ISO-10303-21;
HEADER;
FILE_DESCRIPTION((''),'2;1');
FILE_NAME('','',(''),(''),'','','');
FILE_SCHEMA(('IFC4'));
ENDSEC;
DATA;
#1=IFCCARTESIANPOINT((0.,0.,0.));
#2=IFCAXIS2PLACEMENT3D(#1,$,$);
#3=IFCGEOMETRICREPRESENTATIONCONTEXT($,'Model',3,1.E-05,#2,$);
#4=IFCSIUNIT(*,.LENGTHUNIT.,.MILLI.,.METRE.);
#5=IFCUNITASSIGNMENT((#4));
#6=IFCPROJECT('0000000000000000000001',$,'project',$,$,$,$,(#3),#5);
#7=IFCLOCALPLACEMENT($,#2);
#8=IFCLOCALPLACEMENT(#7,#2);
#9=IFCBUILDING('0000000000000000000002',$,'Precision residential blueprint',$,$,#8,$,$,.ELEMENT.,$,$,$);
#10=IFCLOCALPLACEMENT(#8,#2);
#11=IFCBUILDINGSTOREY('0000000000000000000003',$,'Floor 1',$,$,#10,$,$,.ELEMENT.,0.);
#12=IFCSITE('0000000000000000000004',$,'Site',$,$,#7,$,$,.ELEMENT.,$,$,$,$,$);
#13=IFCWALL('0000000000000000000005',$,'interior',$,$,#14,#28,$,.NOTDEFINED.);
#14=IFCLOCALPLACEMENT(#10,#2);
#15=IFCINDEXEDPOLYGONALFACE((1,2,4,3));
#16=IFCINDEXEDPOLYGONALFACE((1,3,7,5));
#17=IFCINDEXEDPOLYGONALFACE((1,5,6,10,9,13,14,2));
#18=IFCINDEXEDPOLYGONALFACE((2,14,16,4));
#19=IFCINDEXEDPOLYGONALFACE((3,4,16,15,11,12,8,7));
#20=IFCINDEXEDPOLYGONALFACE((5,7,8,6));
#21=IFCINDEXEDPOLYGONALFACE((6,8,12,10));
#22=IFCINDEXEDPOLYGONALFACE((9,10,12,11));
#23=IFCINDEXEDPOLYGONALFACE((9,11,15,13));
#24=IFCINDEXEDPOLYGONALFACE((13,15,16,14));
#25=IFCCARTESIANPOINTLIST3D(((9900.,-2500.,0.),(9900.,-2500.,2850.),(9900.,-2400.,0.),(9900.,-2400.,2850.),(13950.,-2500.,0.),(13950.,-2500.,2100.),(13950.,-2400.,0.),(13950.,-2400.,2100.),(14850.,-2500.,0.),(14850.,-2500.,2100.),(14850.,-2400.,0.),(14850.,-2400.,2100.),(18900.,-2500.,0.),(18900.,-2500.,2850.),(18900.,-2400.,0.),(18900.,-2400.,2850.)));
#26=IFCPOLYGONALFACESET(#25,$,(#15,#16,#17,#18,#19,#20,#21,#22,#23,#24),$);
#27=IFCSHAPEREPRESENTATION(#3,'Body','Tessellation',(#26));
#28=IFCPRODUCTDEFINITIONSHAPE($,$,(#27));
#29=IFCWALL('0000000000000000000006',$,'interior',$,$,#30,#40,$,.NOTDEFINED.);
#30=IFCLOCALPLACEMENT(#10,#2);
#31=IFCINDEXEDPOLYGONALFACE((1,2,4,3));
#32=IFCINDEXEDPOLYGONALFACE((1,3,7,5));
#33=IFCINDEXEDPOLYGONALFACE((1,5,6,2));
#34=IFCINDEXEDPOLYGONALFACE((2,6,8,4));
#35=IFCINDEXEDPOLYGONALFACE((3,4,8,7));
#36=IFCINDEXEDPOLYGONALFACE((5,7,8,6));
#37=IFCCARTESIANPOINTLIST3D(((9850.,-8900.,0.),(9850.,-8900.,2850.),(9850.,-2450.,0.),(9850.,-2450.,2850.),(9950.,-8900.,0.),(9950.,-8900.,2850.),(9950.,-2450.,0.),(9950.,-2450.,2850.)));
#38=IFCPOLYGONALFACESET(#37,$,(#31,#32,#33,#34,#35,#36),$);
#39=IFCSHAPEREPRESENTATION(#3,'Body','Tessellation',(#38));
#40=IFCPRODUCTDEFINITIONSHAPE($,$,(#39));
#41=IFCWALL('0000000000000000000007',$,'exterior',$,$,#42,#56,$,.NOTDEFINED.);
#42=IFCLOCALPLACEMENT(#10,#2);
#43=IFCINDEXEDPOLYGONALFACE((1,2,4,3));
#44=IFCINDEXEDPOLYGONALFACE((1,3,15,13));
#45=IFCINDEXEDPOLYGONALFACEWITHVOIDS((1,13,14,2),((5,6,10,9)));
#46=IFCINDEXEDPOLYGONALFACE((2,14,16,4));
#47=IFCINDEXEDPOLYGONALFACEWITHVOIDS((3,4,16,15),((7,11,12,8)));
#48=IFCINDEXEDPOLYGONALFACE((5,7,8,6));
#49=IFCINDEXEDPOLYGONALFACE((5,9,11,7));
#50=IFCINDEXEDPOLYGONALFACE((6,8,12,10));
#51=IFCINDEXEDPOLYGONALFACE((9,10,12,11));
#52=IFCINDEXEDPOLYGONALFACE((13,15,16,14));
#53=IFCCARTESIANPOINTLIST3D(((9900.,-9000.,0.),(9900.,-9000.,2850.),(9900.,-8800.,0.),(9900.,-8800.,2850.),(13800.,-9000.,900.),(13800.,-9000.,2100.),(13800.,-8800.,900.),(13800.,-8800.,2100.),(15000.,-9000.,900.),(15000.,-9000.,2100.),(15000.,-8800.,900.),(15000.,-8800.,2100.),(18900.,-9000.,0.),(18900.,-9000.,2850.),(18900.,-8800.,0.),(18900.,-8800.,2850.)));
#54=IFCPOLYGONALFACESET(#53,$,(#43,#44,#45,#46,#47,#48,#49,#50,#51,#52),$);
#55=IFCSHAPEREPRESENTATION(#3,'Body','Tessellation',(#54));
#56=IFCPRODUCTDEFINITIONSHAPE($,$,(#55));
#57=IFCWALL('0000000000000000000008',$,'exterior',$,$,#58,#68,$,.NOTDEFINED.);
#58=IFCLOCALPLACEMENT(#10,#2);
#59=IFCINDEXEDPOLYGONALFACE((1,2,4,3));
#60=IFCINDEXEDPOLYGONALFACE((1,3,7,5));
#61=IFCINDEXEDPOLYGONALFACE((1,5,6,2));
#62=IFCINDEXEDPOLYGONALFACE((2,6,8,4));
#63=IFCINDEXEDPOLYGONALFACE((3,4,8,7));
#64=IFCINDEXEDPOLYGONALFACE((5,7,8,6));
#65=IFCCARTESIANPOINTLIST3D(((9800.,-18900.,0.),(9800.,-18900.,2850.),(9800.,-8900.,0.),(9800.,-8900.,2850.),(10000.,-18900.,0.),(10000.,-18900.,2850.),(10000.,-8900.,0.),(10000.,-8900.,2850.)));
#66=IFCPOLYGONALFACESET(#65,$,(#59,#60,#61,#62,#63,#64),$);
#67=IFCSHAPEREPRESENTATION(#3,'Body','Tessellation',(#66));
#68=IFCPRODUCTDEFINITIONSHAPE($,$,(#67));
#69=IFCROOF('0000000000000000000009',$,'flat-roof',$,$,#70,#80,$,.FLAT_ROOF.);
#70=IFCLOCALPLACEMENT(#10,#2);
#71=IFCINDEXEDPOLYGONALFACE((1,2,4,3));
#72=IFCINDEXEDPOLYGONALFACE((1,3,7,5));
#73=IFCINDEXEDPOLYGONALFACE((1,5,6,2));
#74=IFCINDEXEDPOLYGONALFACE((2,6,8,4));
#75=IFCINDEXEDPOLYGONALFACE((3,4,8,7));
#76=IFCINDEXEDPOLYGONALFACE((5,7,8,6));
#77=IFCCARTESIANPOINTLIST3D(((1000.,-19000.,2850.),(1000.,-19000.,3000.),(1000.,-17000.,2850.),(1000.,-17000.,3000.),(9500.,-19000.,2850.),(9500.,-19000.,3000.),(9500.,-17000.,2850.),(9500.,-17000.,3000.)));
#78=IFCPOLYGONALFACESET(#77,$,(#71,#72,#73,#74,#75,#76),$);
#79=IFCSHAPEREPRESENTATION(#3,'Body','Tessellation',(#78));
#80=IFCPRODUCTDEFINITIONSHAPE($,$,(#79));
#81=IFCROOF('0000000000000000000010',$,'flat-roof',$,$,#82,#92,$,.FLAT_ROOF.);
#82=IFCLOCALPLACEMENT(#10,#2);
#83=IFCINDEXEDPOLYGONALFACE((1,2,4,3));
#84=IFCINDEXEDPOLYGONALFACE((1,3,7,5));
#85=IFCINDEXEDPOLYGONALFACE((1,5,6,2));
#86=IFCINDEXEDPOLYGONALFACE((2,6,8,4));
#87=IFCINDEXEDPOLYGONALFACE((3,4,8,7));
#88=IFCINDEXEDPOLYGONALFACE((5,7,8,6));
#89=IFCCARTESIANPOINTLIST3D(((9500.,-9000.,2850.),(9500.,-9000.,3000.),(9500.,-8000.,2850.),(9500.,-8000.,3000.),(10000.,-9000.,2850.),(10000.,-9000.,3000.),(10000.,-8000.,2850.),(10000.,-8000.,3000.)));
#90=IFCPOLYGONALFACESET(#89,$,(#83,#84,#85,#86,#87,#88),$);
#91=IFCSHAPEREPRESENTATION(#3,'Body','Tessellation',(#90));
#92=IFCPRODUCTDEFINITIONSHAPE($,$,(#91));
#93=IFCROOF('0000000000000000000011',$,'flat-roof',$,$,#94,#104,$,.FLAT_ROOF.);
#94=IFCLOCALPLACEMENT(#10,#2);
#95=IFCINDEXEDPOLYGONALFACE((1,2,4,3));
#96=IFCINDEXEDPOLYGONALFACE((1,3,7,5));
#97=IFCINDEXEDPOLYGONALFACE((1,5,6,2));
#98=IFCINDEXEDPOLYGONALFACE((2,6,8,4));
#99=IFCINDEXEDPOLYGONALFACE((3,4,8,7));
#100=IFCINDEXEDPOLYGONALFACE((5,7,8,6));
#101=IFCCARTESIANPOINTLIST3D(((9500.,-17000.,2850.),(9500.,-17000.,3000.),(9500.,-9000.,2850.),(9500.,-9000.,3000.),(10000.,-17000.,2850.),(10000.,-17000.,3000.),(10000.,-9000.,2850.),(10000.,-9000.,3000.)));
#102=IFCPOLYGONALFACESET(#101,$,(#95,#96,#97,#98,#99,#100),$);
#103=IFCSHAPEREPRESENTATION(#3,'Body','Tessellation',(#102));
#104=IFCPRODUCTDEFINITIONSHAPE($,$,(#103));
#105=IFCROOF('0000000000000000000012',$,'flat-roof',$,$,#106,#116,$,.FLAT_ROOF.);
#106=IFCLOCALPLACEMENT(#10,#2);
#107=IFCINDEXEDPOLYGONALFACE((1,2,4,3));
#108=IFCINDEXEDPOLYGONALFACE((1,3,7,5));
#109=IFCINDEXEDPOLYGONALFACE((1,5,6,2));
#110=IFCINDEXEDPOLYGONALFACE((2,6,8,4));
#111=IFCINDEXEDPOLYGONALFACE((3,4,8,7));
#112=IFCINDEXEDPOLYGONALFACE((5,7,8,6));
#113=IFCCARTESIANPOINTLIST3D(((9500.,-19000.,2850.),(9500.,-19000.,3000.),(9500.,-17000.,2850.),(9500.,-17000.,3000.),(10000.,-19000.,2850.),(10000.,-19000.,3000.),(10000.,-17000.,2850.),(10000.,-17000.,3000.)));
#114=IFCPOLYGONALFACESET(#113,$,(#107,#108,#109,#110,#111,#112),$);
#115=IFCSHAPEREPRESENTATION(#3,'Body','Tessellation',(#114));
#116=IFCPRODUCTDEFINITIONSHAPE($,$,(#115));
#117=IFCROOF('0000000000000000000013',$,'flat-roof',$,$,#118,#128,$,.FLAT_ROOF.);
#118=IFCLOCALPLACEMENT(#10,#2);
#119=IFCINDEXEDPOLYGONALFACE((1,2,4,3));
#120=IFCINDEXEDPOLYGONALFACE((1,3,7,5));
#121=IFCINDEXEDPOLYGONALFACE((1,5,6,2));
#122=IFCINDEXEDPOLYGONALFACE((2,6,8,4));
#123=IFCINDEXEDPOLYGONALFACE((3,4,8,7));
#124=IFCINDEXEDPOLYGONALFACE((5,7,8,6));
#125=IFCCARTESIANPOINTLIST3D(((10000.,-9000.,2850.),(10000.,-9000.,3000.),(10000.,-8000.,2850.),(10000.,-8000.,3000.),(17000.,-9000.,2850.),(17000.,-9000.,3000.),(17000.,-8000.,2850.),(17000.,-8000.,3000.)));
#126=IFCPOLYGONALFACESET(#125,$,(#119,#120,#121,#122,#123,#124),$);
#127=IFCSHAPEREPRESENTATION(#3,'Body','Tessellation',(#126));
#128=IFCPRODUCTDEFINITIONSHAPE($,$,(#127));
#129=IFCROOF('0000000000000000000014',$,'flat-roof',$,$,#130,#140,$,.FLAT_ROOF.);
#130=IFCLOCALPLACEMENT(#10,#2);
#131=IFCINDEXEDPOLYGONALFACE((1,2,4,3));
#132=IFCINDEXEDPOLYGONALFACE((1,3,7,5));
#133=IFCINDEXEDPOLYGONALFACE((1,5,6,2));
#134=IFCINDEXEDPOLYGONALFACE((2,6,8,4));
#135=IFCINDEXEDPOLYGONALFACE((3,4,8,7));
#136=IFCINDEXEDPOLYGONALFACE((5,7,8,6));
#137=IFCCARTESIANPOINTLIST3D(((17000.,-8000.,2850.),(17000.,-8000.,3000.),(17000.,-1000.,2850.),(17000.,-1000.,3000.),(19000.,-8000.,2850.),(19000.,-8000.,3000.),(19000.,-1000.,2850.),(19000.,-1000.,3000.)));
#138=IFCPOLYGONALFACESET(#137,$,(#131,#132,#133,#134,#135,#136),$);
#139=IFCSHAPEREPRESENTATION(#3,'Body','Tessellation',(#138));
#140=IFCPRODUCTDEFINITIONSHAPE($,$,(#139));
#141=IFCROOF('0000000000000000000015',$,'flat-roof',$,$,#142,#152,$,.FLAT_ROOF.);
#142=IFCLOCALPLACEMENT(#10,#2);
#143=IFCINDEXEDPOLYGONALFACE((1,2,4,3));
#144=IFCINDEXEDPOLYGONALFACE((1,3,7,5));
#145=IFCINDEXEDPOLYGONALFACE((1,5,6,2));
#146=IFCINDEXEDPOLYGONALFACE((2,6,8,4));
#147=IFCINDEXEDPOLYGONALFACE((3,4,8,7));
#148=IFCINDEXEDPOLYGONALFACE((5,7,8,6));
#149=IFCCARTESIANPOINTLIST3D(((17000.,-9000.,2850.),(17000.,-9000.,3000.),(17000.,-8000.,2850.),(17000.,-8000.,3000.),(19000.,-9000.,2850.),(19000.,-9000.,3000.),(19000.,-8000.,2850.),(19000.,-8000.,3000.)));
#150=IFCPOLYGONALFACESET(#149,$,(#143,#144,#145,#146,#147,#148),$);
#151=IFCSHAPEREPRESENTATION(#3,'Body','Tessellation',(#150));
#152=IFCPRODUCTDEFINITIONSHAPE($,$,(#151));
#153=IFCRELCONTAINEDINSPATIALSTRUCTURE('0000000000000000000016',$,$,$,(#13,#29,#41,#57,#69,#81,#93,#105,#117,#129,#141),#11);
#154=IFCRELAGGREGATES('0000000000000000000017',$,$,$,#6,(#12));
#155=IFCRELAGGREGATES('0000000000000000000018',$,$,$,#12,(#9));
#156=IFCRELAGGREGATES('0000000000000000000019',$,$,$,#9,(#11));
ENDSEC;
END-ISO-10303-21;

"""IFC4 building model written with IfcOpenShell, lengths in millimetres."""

from ifc_helpers import new_model, si_unit, frame, origin, place, context, project, spatial, polyline, outline, extrude, element, save


model = new_model("IFC4")

# Units and contexts
model_context = context("Model", 3, precision=1e-05, world=origin())
ifc_project = project(units=[si_unit("LENGTHUNIT", "METRE", prefix="MILLI")], contexts=[model_context])

# Site, building, storey
site_placement = place(None, origin())
site = spatial("IfcSite", under=ifc_project, at=site_placement, Name="Site", CompositionType="ELEMENT")
building_placement = place(site_placement, origin())
building = spatial("IfcBuilding", under=site, at=building_placement, Name="Precision residential blueprint", CompositionType="ELEMENT")
storey_placement = place(building_placement, origin())
storey = spatial("IfcBuildingStorey", under=building, at=storey_placement, Name="Floor 1", CompositionType="ELEMENT", Elevation=0.0)

# Wall, opening
wall_1_placement = place(storey_placement, origin())
wall_1 = element("IfcWall", 1, at=wall_1_placement, inside=storey, Name="interior", PredefinedType="NOTDEFINED", context=model_context, shape_type="SweptSolid", body=[
    extrude(outline(polyline([(9900.0, -2400.0), (18900.0, -2400.0), (18900.0, -2500.0), (9900.0, -2500.0), (9900.0, -2400.0)])), origin(), (0.0, 0.0, 1.0), 2850.0),
])
opening_1_placement = place(storey_placement, origin())
element("IfcOpeningElement", 2, at=opening_1_placement, cuts=wall_1, PredefinedType="OPENING", context=model_context, shape_type="SweptSolid", body=[
    extrude(outline(polyline([(13950.0, -2400.0), (14850.0, -2400.0), (14850.0, -2500.0), (13950.0, -2500.0), (13950.0, -2400.0)])), origin(), (0.0, 0.0, 1.0), 2100.0),
])

# Wall
wall_2_placement = place(storey_placement, origin())
element("IfcWall", 3, at=wall_2_placement, inside=storey, Name="interior", PredefinedType="NOTDEFINED", context=model_context, shape_type="SweptSolid", body=[
    extrude(outline(polyline([(9950.0, -2450.0), (9950.0, -8900.0), (9850.0, -8900.0), (9850.0, -2450.0), (9950.0, -2450.0)])), origin(), (0.0, 0.0, 1.0), 2850.0),
])

# Wall, opening
wall_3_placement = place(storey_placement, origin())
wall_3 = element("IfcWall", 4, at=wall_3_placement, inside=storey, Name="exterior", PredefinedType="NOTDEFINED", context=model_context, shape_type="SweptSolid", body=[
    extrude(outline(polyline([(9900.0, -8800.0), (18900.0, -8800.0), (18900.0, -9000.0), (9900.0, -9000.0), (9900.0, -8800.0)])), origin(), (0.0, 0.0, 1.0), 2850.0),
])
opening_2_placement = place(storey_placement, origin())
element("IfcOpeningElement", 5, at=opening_2_placement, cuts=wall_3, PredefinedType="OPENING", context=model_context, shape_type="SweptSolid", body=[
    extrude(outline(polyline([(13800.0, -8800.0), (15000.0, -8800.0), (15000.0, -9000.0), (13800.0, -9000.0), (13800.0, -8800.0)])), frame((0.0, 0.0, 900.0)), (0.0, 0.0, 1.0), 1200.0),
])

# Wall
wall_4_placement = place(storey_placement, origin())
element("IfcWall", 6, at=wall_4_placement, inside=storey, Name="exterior", PredefinedType="NOTDEFINED", context=model_context, shape_type="SweptSolid", body=[
    extrude(outline(polyline([(10000.0, -8900.0), (10000.0, -18900.0), (9800.0, -18900.0), (9800.0, -8900.0), (10000.0, -8900.0)])), origin(), (0.0, 0.0, 1.0), 2850.0),
])

# Roofs
roof_1_placement = place(storey_placement, origin())
element("IfcRoof", 7, at=roof_1_placement, inside=storey, Name="flat-roof", PredefinedType="FLAT_ROOF", context=model_context, shape_type="SweptSolid", body=[
    extrude(outline(polyline([(1000.0, -19000.0), (9500.0, -19000.0), (9500.0, -17000.0), (1000.0, -17000.0), (1000.0, -19000.0)])), frame((0.0, 0.0, 2850.0)), (0.0, 0.0, 1.0), 150.0),
])
roof_2_placement = place(storey_placement, origin())
element("IfcRoof", 8, at=roof_2_placement, inside=storey, Name="flat-roof", PredefinedType="FLAT_ROOF", context=model_context, shape_type="SweptSolid", body=[
    extrude(outline(polyline([(9500.0, -9000.0), (10000.0, -9000.0), (10000.0, -8000.0), (9500.0, -8000.0), (9500.0, -9000.0)])), frame((0.0, 0.0, 2850.0)), (0.0, 0.0, 1.0), 150.0),
])
roof_3_placement = place(storey_placement, origin())
element("IfcRoof", 9, at=roof_3_placement, inside=storey, Name="flat-roof", PredefinedType="FLAT_ROOF", context=model_context, shape_type="SweptSolid", body=[
    extrude(outline(polyline([(9500.0, -17000.0), (10000.0, -17000.0), (10000.0, -9000.0), (9500.0, -9000.0), (9500.0, -17000.0)])), frame((0.0, 0.0, 2850.0)), (0.0, 0.0, 1.0), 150.0),
])
roof_4_placement = place(storey_placement, origin())
element("IfcRoof", 10, at=roof_4_placement, inside=storey, Name="flat-roof", PredefinedType="FLAT_ROOF", context=model_context, shape_type="SweptSolid", body=[
    extrude(outline(polyline([(9500.0, -19000.0), (10000.0, -19000.0), (10000.0, -17000.0), (9500.0, -17000.0), (9500.0, -19000.0)])), frame((0.0, 0.0, 2850.0)), (0.0, 0.0, 1.0), 150.0),
])
roof_5_placement = place(storey_placement, origin())
element("IfcRoof", 11, at=roof_5_placement, inside=storey, Name="flat-roof", PredefinedType="FLAT_ROOF", context=model_context, shape_type="SweptSolid", body=[
    extrude(outline(polyline([(10000.0, -9000.0), (17000.0, -9000.0), (17000.0, -8000.0), (10000.0, -8000.0), (10000.0, -9000.0)])), frame((0.0, 0.0, 2850.0)), (0.0, 0.0, 1.0), 150.0),
])
roof_6_placement = place(storey_placement, origin())
element("IfcRoof", 12, at=roof_6_placement, inside=storey, Name="flat-roof", PredefinedType="FLAT_ROOF", context=model_context, shape_type="SweptSolid", body=[
    extrude(outline(polyline([(17000.0, -8000.0), (19000.0, -8000.0), (19000.0, -1000.0), (17000.0, -1000.0), (17000.0, -8000.0)])), frame((0.0, 0.0, 2850.0)), (0.0, 0.0, 1.0), 150.0),
])
roof_7_placement = place(storey_placement, origin())
element("IfcRoof", 13, at=roof_7_placement, inside=storey, Name="flat-roof", PredefinedType="FLAT_ROOF", context=model_context, shape_type="SweptSolid", body=[
    extrude(outline(polyline([(17000.0, -9000.0), (19000.0, -9000.0), (19000.0, -8000.0), (17000.0, -8000.0), (17000.0, -9000.0)])), frame((0.0, 0.0, 2850.0)), (0.0, 0.0, 1.0), 150.0),
])

save(model, "model.ifc")
